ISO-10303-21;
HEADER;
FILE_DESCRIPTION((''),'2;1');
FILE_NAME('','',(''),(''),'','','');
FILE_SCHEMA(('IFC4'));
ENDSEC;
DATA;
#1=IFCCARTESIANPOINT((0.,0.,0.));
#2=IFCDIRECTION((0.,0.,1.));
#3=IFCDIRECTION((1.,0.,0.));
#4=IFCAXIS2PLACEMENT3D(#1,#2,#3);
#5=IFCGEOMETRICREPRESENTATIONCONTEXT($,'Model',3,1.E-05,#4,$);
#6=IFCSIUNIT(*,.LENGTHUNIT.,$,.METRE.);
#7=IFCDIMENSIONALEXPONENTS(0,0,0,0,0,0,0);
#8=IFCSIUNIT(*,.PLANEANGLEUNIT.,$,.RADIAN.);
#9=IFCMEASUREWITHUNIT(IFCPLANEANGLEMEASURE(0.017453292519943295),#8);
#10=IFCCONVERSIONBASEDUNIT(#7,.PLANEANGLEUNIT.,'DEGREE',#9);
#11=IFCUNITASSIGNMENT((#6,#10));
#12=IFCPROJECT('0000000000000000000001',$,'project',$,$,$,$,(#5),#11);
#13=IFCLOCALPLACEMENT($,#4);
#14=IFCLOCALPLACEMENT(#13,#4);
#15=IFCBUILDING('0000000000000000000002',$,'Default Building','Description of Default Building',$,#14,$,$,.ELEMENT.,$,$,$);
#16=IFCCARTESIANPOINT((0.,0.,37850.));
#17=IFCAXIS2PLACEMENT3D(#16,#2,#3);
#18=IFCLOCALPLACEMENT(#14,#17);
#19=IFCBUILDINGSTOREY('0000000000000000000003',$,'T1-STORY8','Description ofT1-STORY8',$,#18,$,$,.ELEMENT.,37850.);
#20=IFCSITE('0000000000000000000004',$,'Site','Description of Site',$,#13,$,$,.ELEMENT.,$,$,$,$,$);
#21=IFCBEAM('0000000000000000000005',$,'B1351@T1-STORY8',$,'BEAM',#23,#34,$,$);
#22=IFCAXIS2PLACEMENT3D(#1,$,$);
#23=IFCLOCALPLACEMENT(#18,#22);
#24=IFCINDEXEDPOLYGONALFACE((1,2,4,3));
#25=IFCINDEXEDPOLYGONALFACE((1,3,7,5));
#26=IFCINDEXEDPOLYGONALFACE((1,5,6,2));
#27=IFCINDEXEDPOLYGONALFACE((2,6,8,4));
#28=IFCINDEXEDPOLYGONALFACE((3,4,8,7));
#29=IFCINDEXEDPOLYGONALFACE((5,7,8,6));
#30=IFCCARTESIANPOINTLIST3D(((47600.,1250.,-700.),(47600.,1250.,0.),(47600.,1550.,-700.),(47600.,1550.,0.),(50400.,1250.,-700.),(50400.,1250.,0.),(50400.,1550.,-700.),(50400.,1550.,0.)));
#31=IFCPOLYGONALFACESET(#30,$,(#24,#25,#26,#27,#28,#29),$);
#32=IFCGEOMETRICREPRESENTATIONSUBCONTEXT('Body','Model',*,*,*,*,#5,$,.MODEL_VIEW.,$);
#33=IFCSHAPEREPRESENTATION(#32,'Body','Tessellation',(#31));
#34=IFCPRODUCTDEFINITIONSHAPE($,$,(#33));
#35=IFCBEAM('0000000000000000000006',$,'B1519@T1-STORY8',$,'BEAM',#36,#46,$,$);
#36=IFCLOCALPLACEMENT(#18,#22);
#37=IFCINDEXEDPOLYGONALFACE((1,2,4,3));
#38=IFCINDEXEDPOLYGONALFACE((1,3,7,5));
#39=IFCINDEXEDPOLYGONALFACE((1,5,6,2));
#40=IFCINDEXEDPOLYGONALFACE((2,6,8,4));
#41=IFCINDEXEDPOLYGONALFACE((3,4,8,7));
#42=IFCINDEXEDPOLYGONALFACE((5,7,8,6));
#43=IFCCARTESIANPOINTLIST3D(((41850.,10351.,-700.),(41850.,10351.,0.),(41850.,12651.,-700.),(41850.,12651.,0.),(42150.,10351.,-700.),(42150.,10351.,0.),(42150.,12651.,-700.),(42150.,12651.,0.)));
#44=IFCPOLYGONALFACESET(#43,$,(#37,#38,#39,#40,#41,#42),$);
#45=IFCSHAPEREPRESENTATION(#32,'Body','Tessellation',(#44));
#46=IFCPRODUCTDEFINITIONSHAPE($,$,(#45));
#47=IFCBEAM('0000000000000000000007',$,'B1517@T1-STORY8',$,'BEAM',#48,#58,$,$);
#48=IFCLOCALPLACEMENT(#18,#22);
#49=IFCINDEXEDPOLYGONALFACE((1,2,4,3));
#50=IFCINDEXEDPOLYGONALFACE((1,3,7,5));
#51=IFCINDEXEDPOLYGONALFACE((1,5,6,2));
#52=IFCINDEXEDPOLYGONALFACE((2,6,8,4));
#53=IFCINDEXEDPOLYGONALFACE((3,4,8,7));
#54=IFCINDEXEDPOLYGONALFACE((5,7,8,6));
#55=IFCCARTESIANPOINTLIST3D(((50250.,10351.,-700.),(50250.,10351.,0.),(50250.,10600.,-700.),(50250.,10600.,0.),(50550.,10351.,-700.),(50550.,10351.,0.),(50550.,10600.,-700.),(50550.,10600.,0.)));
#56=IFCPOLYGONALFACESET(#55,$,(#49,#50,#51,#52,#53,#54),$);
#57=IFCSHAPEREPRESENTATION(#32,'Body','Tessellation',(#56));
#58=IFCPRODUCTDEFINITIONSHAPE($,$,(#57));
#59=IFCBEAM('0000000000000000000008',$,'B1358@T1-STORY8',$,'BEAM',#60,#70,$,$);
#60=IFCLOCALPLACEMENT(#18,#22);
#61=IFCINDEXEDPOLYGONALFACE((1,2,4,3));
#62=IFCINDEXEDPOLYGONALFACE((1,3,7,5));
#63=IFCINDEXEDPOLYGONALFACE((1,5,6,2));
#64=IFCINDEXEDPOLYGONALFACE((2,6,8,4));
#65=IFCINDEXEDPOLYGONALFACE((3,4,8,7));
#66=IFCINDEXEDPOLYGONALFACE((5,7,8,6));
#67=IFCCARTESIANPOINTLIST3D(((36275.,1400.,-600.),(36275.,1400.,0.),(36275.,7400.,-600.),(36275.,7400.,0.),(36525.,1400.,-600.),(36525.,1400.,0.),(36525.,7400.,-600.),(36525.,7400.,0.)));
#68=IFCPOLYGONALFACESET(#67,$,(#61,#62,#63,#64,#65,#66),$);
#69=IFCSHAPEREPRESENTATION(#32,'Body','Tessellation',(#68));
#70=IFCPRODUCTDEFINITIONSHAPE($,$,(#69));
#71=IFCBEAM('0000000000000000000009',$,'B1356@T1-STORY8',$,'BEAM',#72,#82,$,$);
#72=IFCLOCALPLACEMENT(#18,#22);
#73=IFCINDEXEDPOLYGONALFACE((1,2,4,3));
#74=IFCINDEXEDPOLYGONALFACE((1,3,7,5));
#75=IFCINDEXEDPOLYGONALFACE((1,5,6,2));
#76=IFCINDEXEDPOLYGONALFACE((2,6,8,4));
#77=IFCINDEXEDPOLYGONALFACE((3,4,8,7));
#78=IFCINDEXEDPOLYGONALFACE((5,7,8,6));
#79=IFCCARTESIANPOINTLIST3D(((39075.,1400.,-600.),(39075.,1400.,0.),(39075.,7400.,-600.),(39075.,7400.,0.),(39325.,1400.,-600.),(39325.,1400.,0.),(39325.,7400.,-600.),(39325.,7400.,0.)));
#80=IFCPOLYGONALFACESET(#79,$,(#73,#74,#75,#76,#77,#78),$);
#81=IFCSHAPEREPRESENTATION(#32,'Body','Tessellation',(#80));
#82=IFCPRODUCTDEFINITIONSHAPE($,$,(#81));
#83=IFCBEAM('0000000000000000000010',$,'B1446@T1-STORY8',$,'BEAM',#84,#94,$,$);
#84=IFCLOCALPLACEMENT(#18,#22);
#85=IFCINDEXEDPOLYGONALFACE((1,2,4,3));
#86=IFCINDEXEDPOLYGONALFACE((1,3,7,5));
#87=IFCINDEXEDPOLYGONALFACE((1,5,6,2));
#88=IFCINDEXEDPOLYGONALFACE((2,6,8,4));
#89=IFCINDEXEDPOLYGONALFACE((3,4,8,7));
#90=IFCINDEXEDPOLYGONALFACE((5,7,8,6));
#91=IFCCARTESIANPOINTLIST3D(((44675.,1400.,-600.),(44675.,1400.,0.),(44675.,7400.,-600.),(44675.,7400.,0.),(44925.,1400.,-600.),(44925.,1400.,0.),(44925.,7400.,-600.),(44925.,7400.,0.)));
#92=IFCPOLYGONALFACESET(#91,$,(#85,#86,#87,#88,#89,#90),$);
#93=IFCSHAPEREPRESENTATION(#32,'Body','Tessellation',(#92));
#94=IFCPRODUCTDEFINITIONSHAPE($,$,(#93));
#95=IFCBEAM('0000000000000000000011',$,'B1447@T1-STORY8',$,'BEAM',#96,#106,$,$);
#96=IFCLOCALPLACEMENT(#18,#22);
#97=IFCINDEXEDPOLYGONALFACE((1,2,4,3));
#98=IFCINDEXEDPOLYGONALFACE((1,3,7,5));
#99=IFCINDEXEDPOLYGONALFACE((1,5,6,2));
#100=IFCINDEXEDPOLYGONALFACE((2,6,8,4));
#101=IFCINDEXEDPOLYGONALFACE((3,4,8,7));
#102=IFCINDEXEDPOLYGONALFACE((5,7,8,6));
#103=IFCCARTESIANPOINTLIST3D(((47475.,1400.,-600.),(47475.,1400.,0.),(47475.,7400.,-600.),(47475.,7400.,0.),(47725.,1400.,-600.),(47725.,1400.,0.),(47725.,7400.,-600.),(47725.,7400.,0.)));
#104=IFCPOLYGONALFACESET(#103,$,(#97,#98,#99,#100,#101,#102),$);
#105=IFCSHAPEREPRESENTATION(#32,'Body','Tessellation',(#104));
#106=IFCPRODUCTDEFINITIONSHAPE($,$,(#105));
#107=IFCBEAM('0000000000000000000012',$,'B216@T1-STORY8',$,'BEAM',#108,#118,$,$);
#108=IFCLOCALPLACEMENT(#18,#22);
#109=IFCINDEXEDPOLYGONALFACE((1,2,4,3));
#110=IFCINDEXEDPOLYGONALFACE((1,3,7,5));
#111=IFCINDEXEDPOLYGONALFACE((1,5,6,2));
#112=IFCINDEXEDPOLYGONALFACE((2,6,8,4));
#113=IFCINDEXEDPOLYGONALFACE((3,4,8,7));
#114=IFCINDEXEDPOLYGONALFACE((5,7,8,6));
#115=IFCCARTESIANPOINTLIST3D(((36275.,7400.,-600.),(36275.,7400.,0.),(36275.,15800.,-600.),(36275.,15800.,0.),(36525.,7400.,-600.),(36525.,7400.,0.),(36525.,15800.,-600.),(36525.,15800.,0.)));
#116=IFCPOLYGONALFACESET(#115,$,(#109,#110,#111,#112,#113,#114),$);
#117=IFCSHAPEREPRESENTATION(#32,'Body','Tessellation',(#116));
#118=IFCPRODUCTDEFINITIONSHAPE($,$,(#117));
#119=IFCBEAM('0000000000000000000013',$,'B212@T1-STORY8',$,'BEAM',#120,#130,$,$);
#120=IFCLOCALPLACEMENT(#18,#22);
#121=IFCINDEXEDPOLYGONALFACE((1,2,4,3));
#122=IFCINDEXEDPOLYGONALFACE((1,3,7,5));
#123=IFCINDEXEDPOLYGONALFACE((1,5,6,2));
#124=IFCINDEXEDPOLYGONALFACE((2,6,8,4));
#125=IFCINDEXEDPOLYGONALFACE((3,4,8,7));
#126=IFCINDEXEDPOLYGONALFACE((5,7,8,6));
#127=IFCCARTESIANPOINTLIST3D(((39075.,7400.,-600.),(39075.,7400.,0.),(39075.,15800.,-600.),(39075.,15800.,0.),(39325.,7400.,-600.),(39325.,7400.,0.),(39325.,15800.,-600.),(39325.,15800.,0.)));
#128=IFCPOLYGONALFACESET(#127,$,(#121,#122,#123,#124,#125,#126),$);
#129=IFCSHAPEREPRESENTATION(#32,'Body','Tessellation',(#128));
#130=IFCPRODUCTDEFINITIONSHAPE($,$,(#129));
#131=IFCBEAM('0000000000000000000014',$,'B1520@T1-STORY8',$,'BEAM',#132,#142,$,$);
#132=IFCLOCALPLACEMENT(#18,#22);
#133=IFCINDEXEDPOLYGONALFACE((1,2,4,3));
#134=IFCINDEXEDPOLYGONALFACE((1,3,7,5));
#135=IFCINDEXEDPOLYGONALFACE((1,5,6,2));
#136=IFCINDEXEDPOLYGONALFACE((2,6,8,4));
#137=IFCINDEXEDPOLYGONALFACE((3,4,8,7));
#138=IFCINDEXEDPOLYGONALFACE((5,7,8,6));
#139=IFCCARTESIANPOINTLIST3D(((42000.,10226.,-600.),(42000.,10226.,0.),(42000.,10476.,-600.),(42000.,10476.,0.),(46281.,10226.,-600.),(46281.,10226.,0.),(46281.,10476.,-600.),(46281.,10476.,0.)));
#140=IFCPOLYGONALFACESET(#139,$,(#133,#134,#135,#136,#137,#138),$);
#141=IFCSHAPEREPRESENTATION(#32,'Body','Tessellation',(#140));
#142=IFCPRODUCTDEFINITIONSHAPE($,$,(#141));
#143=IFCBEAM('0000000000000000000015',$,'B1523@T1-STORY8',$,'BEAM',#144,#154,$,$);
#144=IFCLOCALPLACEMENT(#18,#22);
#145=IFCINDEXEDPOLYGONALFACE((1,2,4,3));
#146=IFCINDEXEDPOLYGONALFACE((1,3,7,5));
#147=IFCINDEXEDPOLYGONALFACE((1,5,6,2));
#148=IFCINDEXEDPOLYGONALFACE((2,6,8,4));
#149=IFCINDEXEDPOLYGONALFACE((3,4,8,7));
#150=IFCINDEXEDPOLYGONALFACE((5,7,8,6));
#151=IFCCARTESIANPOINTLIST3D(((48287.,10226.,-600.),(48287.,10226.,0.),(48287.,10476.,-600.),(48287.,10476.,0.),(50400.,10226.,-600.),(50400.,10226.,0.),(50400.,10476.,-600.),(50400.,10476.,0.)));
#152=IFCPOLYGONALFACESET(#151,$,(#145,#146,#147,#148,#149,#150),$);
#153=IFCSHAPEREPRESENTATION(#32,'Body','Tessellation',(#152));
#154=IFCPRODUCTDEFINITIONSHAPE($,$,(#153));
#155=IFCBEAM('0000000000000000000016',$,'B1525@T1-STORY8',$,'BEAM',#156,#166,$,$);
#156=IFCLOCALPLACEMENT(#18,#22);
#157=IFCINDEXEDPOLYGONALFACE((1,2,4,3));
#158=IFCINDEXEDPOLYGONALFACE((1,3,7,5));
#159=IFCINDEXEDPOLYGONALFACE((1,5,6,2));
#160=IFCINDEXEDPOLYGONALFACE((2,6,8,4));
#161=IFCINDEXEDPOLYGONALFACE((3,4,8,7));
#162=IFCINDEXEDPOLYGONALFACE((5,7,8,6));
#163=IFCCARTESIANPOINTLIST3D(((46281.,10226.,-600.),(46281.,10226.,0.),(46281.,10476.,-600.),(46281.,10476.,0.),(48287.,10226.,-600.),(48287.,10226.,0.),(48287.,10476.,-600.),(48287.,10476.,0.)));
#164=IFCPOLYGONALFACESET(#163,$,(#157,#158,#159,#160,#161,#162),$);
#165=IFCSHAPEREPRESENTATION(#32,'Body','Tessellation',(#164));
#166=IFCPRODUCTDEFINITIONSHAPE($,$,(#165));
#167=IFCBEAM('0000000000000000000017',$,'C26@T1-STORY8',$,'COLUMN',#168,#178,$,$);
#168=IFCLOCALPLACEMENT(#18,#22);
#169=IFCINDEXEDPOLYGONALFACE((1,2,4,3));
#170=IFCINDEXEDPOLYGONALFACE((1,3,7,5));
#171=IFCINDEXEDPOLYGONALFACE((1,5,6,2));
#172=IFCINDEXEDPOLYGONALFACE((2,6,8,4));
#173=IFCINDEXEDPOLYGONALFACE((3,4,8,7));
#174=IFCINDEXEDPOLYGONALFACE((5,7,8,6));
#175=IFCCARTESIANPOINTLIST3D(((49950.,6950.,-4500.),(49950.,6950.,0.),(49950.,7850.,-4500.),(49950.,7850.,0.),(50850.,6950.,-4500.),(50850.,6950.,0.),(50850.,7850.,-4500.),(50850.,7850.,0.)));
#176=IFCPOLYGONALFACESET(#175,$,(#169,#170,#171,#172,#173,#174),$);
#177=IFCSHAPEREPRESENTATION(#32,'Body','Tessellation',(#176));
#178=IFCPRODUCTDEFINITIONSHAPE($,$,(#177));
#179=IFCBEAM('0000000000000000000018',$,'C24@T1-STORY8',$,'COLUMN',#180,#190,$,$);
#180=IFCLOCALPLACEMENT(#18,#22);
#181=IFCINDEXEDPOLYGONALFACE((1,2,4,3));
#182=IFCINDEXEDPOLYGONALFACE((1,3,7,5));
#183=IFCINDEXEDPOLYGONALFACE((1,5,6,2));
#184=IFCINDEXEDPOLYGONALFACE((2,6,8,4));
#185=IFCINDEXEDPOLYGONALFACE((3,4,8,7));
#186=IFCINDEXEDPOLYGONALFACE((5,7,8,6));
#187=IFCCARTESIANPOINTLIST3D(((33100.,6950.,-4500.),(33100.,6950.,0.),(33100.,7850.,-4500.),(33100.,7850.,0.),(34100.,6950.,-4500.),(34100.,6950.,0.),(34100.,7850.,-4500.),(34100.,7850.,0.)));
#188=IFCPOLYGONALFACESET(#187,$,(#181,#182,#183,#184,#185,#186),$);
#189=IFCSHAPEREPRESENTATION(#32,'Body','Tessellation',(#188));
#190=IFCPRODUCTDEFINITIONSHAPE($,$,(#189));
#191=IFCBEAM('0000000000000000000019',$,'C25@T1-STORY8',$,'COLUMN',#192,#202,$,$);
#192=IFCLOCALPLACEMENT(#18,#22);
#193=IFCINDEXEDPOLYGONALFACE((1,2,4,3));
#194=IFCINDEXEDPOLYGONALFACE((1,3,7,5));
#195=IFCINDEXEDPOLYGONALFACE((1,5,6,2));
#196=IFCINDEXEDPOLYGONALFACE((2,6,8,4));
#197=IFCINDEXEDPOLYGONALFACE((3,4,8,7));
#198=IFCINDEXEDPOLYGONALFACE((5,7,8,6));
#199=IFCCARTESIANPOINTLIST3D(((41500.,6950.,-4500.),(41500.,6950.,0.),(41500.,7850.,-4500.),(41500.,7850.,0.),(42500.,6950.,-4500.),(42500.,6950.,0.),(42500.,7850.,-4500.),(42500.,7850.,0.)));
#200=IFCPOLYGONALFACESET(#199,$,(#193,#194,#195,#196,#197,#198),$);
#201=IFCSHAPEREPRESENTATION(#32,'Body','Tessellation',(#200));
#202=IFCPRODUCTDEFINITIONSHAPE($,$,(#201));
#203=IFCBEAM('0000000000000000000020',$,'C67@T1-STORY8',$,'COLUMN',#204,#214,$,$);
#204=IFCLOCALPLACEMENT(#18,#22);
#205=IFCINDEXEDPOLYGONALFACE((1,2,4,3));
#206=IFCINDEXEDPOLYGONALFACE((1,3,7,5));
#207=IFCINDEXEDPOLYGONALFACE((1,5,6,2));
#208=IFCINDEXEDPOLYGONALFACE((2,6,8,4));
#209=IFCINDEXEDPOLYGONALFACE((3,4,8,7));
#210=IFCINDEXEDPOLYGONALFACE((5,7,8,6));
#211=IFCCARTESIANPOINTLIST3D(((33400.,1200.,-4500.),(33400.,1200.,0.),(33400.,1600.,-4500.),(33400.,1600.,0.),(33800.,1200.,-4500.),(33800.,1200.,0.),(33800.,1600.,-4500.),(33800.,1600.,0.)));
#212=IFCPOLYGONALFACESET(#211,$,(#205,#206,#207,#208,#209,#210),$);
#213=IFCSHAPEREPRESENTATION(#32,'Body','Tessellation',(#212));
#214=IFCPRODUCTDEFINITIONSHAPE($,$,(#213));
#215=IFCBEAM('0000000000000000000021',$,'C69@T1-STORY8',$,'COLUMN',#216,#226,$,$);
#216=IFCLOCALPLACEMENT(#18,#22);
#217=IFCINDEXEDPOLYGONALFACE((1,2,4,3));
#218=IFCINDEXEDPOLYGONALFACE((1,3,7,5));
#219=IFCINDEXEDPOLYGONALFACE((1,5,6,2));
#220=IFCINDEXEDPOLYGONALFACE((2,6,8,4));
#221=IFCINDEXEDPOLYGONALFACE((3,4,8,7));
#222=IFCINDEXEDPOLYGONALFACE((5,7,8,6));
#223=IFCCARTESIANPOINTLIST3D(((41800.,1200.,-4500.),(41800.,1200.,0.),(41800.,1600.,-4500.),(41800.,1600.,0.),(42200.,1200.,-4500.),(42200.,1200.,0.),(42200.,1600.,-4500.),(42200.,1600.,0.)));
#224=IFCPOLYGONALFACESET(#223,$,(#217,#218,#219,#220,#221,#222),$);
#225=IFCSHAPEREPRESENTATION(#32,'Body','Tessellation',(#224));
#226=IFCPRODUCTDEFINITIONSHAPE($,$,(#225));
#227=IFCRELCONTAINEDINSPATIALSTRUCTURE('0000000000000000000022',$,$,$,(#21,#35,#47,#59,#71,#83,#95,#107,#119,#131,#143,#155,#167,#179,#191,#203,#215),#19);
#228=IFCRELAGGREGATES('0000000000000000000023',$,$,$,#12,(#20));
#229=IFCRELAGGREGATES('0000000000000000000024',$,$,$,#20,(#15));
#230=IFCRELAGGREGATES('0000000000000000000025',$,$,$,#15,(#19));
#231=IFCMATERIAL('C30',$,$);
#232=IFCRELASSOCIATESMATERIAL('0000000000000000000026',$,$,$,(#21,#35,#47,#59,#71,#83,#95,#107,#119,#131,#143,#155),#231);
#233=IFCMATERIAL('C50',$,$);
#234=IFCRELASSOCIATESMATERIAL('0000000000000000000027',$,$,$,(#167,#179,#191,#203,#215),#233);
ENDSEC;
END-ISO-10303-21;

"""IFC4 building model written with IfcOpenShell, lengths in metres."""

from ifc_helpers import new_model, entity, si_unit, converted_unit, frame, origin_with_axes, place, context, subcontext, project, spatial, rectangle, extrude, material, element, save


model = new_model("IFC4")

# Units and contexts
model_context = context("Model", 3, precision=1e-05, world=origin_with_axes())
body_context = subcontext(model_context, "Body", "Model", "MODEL_VIEW")
ifc_project = project(units=[si_unit("LENGTHUNIT", "METRE"), converted_unit("PLANEANGLEUNIT", "DEGREE", entity("IfcPlaneAngleMeasure", 0.017453292519943295), si_unit("PLANEANGLEUNIT", "RADIAN"), dimensions=[0, 0, 0, 0, 0, 0, 0])], contexts=[model_context])

# Site, building, storey
site_placement = place(None, origin_with_axes())
site = spatial("IfcSite", under=ifc_project, at=site_placement, Name="Site", Description="Description of Site", CompositionType="ELEMENT")
building_placement = place(site_placement, origin_with_axes())
building = spatial("IfcBuilding", under=site, at=building_placement, Name="Default Building", Description="Description of Default Building", CompositionType="ELEMENT")
storey_placement = place(building_placement, frame((0.0, 0.0, 37850.0), z_axis=(0.0, 0.0, 1.0), x_axis=(1.0, 0.0, 0.0)))
storey = spatial("IfcBuildingStorey", under=building, at=storey_placement, Name="T1-STORY8", Description="Description ofT1-STORY8", CompositionType="ELEMENT", Elevation=37850.0)

# Beams
ifc_material_1 = material(Name="C30")
for number, where, z_axis, x_axis, name in (
    (1, (47600.0, 1400.0, -350.0), (1.0, 0.0, 0.0), (0.0, 1.0, 0.0), "B1351@T1-STORY8"),
):
    element("IfcBeam", number, at=place(storey_placement, frame(where, z_axis=z_axis, x_axis=x_axis)), inside=storey, material=ifc_material_1, Name=name, ObjectType="BEAM", context=body_context, shape_type="SweptSolid", body=[
        extrude(rectangle(XDim=300.0, YDim=700.0), origin_with_axes(), (0.0, 0.0, 1.0), 2800.0),
    ])
beam_1_placement = place(storey_placement, frame((42000.0, 10351.0, -350.0), z_axis=(0.0, 1.0, 0.0), x_axis=(-1.0, 0.0, 0.0)))
element("IfcBeam", 2, at=beam_1_placement, inside=storey, material=ifc_material_1, Name="B1519@T1-STORY8", ObjectType="BEAM", context=body_context, shape_type="SweptSolid", body=[
    extrude(rectangle(XDim=300.0, YDim=700.0), origin_with_axes(), (0.0, 0.0, 1.0), 2300.0),
])
beam_2_placement = place(storey_placement, frame((50400.0, 10351.0, -350.0), z_axis=(0.0, 1.0, 0.0), x_axis=(-1.0, 0.0, 0.0)))
element("IfcBeam", 3, at=beam_2_placement, inside=storey, material=ifc_material_1, Name="B1517@T1-STORY8", ObjectType="BEAM", context=body_context, shape_type="SweptSolid", body=[
    extrude(rectangle(XDim=300.0, YDim=700.0), origin_with_axes(), (0.0, 0.0, 1.0), 249.0),
])
for number, where, z_axis, x_axis, name in (
    (4, (36400.0, 1400.0, -300.0), (0.0, 1.0, 0.0), (-1.0, 0.0, 0.0), "B1358@T1-STORY8"),
    (5, (39200.0, 1400.0, -300.0), (0.0, 1.0, 0.0), (-1.0, 0.0, 0.0), "B1356@T1-STORY8"),
    (6, (44800.0, 1400.0, -300.0), (0.0, 1.0, 0.0), (-1.0, 0.0, 0.0), "B1446@T1-STORY8"),
    (7, (47600.0, 1400.0, -300.0), (0.0, 1.0, 0.0), (-1.0, 0.0, 0.0), "B1447@T1-STORY8"),
):
    element("IfcBeam", number, at=place(storey_placement, frame(where, z_axis=z_axis, x_axis=x_axis)), inside=storey, material=ifc_material_1, Name=name, ObjectType="BEAM", context=body_context, shape_type="SweptSolid", body=[
        extrude(rectangle(XDim=250.0, YDim=600.0), origin_with_axes(), (0.0, 0.0, 1.0), 6000.0),
    ])
for number, where, z_axis, x_axis, name in (
    (8, (36400.0, 7400.0, -300.0), (0.0, 1.0, 0.0), (-1.0, 0.0, 0.0), "B216@T1-STORY8"),
    (9, (39200.0, 7400.0, -300.0), (0.0, 1.0, 0.0), (-1.0, 0.0, 0.0), "B212@T1-STORY8"),
):
    element("IfcBeam", number, at=place(storey_placement, frame(where, z_axis=z_axis, x_axis=x_axis)), inside=storey, material=ifc_material_1, Name=name, ObjectType="BEAM", context=body_context, shape_type="SweptSolid", body=[
        extrude(rectangle(XDim=250.0, YDim=600.0), origin_with_axes(), (0.0, 0.0, 1.0), 8400.0),
    ])
beam_3_placement = place(storey_placement, frame((42000.0, 10351.0, -300.0), z_axis=(1.0, 0.0, 0.0), x_axis=(0.0, 1.0, 0.0)))
element("IfcBeam", 10, at=beam_3_placement, inside=storey, material=ifc_material_1, Name="B1520@T1-STORY8", ObjectType="BEAM", context=body_context, shape_type="SweptSolid", body=[
    extrude(rectangle(XDim=250.0, YDim=600.0), origin_with_axes(), (0.0, 0.0, 1.0), 4281.0),
])
beam_4_placement = place(storey_placement, frame((48287.0, 10351.0, -300.0), z_axis=(1.0, 0.0, 0.0), x_axis=(0.0, 1.0, 0.0)))
element("IfcBeam", 11, at=beam_4_placement, inside=storey, material=ifc_material_1, Name="B1523@T1-STORY8", ObjectType="BEAM", context=body_context, shape_type="SweptSolid", body=[
    extrude(rectangle(XDim=250.0, YDim=600.0), origin_with_axes(), (0.0, 0.0, 1.0), 2113.0),
])
beam_5_placement = place(storey_placement, frame((46281.0, 10351.0, -300.0), z_axis=(1.0, 0.0, 0.0), x_axis=(0.0, 1.0, 0.0)))
element("IfcBeam", 12, at=beam_5_placement, inside=storey, material=ifc_material_1, Name="B1525@T1-STORY8", ObjectType="BEAM", context=body_context, shape_type="SweptSolid", body=[
    extrude(rectangle(XDim=250.0, YDim=600.0), origin_with_axes(), (0.0, 0.0, 1.0), 2006.0),
])
ifc_material_2 = material(Name="C50")
beam_6_placement = place(storey_placement, frame((50400.0, 7400.0, -4500.0), z_axis=(0.0, 0.0, 1.0), x_axis=(-1.0, 0.0, 0.0)))
element("IfcBeam", 13, at=beam_6_placement, inside=storey, material=ifc_material_2, Name="C26@T1-STORY8", ObjectType="COLUMN", context=body_context, shape_type="SweptSolid", body=[
    extrude(rectangle(XDim=900.0, YDim=900.0), origin_with_axes(), (0.0, 0.0, 1.0), 4500.0),
])
for number, where, z_axis, x_axis, name in (
    (14, (33600.0, 7400.0, -4500.0), (0.0, 0.0, 1.0), (-1.0, 0.0, 0.0), "C24@T1-STORY8"),
    (15, (42000.0, 7400.0, -4500.0), (0.0, 0.0, 1.0), (-1.0, 0.0, 0.0), "C25@T1-STORY8"),
):
    element("IfcBeam", number, at=place(storey_placement, frame(where, z_axis=z_axis, x_axis=x_axis)), inside=storey, material=ifc_material_2, Name=name, ObjectType="COLUMN", context=body_context, shape_type="SweptSolid", body=[
        extrude(rectangle(XDim=1000.0, YDim=900.0), origin_with_axes(), (0.0, 0.0, 1.0), 4500.0),
    ])
for number, where, z_axis, x_axis, name in (
    (16, (33600.0, 1400.0, -4500.0), (0.0, 0.0, 1.0), (-1.0, 0.0, 0.0), "C67@T1-STORY8"),
    (17, (42000.0, 1400.0, -4500.0), (0.0, 0.0, 1.0), (-1.0, 0.0, 0.0), "C69@T1-STORY8"),
):
    element("IfcBeam", number, at=place(storey_placement, frame(where, z_axis=z_axis, x_axis=x_axis)), inside=storey, material=ifc_material_2, Name=name, ObjectType="COLUMN", context=body_context, shape_type="SweptSolid", body=[
        extrude(rectangle(XDim=400.0, YDim=400.0), origin_with_axes(), (0.0, 0.0, 1.0), 4500.0),
    ])

save(model, "model.ifc")
